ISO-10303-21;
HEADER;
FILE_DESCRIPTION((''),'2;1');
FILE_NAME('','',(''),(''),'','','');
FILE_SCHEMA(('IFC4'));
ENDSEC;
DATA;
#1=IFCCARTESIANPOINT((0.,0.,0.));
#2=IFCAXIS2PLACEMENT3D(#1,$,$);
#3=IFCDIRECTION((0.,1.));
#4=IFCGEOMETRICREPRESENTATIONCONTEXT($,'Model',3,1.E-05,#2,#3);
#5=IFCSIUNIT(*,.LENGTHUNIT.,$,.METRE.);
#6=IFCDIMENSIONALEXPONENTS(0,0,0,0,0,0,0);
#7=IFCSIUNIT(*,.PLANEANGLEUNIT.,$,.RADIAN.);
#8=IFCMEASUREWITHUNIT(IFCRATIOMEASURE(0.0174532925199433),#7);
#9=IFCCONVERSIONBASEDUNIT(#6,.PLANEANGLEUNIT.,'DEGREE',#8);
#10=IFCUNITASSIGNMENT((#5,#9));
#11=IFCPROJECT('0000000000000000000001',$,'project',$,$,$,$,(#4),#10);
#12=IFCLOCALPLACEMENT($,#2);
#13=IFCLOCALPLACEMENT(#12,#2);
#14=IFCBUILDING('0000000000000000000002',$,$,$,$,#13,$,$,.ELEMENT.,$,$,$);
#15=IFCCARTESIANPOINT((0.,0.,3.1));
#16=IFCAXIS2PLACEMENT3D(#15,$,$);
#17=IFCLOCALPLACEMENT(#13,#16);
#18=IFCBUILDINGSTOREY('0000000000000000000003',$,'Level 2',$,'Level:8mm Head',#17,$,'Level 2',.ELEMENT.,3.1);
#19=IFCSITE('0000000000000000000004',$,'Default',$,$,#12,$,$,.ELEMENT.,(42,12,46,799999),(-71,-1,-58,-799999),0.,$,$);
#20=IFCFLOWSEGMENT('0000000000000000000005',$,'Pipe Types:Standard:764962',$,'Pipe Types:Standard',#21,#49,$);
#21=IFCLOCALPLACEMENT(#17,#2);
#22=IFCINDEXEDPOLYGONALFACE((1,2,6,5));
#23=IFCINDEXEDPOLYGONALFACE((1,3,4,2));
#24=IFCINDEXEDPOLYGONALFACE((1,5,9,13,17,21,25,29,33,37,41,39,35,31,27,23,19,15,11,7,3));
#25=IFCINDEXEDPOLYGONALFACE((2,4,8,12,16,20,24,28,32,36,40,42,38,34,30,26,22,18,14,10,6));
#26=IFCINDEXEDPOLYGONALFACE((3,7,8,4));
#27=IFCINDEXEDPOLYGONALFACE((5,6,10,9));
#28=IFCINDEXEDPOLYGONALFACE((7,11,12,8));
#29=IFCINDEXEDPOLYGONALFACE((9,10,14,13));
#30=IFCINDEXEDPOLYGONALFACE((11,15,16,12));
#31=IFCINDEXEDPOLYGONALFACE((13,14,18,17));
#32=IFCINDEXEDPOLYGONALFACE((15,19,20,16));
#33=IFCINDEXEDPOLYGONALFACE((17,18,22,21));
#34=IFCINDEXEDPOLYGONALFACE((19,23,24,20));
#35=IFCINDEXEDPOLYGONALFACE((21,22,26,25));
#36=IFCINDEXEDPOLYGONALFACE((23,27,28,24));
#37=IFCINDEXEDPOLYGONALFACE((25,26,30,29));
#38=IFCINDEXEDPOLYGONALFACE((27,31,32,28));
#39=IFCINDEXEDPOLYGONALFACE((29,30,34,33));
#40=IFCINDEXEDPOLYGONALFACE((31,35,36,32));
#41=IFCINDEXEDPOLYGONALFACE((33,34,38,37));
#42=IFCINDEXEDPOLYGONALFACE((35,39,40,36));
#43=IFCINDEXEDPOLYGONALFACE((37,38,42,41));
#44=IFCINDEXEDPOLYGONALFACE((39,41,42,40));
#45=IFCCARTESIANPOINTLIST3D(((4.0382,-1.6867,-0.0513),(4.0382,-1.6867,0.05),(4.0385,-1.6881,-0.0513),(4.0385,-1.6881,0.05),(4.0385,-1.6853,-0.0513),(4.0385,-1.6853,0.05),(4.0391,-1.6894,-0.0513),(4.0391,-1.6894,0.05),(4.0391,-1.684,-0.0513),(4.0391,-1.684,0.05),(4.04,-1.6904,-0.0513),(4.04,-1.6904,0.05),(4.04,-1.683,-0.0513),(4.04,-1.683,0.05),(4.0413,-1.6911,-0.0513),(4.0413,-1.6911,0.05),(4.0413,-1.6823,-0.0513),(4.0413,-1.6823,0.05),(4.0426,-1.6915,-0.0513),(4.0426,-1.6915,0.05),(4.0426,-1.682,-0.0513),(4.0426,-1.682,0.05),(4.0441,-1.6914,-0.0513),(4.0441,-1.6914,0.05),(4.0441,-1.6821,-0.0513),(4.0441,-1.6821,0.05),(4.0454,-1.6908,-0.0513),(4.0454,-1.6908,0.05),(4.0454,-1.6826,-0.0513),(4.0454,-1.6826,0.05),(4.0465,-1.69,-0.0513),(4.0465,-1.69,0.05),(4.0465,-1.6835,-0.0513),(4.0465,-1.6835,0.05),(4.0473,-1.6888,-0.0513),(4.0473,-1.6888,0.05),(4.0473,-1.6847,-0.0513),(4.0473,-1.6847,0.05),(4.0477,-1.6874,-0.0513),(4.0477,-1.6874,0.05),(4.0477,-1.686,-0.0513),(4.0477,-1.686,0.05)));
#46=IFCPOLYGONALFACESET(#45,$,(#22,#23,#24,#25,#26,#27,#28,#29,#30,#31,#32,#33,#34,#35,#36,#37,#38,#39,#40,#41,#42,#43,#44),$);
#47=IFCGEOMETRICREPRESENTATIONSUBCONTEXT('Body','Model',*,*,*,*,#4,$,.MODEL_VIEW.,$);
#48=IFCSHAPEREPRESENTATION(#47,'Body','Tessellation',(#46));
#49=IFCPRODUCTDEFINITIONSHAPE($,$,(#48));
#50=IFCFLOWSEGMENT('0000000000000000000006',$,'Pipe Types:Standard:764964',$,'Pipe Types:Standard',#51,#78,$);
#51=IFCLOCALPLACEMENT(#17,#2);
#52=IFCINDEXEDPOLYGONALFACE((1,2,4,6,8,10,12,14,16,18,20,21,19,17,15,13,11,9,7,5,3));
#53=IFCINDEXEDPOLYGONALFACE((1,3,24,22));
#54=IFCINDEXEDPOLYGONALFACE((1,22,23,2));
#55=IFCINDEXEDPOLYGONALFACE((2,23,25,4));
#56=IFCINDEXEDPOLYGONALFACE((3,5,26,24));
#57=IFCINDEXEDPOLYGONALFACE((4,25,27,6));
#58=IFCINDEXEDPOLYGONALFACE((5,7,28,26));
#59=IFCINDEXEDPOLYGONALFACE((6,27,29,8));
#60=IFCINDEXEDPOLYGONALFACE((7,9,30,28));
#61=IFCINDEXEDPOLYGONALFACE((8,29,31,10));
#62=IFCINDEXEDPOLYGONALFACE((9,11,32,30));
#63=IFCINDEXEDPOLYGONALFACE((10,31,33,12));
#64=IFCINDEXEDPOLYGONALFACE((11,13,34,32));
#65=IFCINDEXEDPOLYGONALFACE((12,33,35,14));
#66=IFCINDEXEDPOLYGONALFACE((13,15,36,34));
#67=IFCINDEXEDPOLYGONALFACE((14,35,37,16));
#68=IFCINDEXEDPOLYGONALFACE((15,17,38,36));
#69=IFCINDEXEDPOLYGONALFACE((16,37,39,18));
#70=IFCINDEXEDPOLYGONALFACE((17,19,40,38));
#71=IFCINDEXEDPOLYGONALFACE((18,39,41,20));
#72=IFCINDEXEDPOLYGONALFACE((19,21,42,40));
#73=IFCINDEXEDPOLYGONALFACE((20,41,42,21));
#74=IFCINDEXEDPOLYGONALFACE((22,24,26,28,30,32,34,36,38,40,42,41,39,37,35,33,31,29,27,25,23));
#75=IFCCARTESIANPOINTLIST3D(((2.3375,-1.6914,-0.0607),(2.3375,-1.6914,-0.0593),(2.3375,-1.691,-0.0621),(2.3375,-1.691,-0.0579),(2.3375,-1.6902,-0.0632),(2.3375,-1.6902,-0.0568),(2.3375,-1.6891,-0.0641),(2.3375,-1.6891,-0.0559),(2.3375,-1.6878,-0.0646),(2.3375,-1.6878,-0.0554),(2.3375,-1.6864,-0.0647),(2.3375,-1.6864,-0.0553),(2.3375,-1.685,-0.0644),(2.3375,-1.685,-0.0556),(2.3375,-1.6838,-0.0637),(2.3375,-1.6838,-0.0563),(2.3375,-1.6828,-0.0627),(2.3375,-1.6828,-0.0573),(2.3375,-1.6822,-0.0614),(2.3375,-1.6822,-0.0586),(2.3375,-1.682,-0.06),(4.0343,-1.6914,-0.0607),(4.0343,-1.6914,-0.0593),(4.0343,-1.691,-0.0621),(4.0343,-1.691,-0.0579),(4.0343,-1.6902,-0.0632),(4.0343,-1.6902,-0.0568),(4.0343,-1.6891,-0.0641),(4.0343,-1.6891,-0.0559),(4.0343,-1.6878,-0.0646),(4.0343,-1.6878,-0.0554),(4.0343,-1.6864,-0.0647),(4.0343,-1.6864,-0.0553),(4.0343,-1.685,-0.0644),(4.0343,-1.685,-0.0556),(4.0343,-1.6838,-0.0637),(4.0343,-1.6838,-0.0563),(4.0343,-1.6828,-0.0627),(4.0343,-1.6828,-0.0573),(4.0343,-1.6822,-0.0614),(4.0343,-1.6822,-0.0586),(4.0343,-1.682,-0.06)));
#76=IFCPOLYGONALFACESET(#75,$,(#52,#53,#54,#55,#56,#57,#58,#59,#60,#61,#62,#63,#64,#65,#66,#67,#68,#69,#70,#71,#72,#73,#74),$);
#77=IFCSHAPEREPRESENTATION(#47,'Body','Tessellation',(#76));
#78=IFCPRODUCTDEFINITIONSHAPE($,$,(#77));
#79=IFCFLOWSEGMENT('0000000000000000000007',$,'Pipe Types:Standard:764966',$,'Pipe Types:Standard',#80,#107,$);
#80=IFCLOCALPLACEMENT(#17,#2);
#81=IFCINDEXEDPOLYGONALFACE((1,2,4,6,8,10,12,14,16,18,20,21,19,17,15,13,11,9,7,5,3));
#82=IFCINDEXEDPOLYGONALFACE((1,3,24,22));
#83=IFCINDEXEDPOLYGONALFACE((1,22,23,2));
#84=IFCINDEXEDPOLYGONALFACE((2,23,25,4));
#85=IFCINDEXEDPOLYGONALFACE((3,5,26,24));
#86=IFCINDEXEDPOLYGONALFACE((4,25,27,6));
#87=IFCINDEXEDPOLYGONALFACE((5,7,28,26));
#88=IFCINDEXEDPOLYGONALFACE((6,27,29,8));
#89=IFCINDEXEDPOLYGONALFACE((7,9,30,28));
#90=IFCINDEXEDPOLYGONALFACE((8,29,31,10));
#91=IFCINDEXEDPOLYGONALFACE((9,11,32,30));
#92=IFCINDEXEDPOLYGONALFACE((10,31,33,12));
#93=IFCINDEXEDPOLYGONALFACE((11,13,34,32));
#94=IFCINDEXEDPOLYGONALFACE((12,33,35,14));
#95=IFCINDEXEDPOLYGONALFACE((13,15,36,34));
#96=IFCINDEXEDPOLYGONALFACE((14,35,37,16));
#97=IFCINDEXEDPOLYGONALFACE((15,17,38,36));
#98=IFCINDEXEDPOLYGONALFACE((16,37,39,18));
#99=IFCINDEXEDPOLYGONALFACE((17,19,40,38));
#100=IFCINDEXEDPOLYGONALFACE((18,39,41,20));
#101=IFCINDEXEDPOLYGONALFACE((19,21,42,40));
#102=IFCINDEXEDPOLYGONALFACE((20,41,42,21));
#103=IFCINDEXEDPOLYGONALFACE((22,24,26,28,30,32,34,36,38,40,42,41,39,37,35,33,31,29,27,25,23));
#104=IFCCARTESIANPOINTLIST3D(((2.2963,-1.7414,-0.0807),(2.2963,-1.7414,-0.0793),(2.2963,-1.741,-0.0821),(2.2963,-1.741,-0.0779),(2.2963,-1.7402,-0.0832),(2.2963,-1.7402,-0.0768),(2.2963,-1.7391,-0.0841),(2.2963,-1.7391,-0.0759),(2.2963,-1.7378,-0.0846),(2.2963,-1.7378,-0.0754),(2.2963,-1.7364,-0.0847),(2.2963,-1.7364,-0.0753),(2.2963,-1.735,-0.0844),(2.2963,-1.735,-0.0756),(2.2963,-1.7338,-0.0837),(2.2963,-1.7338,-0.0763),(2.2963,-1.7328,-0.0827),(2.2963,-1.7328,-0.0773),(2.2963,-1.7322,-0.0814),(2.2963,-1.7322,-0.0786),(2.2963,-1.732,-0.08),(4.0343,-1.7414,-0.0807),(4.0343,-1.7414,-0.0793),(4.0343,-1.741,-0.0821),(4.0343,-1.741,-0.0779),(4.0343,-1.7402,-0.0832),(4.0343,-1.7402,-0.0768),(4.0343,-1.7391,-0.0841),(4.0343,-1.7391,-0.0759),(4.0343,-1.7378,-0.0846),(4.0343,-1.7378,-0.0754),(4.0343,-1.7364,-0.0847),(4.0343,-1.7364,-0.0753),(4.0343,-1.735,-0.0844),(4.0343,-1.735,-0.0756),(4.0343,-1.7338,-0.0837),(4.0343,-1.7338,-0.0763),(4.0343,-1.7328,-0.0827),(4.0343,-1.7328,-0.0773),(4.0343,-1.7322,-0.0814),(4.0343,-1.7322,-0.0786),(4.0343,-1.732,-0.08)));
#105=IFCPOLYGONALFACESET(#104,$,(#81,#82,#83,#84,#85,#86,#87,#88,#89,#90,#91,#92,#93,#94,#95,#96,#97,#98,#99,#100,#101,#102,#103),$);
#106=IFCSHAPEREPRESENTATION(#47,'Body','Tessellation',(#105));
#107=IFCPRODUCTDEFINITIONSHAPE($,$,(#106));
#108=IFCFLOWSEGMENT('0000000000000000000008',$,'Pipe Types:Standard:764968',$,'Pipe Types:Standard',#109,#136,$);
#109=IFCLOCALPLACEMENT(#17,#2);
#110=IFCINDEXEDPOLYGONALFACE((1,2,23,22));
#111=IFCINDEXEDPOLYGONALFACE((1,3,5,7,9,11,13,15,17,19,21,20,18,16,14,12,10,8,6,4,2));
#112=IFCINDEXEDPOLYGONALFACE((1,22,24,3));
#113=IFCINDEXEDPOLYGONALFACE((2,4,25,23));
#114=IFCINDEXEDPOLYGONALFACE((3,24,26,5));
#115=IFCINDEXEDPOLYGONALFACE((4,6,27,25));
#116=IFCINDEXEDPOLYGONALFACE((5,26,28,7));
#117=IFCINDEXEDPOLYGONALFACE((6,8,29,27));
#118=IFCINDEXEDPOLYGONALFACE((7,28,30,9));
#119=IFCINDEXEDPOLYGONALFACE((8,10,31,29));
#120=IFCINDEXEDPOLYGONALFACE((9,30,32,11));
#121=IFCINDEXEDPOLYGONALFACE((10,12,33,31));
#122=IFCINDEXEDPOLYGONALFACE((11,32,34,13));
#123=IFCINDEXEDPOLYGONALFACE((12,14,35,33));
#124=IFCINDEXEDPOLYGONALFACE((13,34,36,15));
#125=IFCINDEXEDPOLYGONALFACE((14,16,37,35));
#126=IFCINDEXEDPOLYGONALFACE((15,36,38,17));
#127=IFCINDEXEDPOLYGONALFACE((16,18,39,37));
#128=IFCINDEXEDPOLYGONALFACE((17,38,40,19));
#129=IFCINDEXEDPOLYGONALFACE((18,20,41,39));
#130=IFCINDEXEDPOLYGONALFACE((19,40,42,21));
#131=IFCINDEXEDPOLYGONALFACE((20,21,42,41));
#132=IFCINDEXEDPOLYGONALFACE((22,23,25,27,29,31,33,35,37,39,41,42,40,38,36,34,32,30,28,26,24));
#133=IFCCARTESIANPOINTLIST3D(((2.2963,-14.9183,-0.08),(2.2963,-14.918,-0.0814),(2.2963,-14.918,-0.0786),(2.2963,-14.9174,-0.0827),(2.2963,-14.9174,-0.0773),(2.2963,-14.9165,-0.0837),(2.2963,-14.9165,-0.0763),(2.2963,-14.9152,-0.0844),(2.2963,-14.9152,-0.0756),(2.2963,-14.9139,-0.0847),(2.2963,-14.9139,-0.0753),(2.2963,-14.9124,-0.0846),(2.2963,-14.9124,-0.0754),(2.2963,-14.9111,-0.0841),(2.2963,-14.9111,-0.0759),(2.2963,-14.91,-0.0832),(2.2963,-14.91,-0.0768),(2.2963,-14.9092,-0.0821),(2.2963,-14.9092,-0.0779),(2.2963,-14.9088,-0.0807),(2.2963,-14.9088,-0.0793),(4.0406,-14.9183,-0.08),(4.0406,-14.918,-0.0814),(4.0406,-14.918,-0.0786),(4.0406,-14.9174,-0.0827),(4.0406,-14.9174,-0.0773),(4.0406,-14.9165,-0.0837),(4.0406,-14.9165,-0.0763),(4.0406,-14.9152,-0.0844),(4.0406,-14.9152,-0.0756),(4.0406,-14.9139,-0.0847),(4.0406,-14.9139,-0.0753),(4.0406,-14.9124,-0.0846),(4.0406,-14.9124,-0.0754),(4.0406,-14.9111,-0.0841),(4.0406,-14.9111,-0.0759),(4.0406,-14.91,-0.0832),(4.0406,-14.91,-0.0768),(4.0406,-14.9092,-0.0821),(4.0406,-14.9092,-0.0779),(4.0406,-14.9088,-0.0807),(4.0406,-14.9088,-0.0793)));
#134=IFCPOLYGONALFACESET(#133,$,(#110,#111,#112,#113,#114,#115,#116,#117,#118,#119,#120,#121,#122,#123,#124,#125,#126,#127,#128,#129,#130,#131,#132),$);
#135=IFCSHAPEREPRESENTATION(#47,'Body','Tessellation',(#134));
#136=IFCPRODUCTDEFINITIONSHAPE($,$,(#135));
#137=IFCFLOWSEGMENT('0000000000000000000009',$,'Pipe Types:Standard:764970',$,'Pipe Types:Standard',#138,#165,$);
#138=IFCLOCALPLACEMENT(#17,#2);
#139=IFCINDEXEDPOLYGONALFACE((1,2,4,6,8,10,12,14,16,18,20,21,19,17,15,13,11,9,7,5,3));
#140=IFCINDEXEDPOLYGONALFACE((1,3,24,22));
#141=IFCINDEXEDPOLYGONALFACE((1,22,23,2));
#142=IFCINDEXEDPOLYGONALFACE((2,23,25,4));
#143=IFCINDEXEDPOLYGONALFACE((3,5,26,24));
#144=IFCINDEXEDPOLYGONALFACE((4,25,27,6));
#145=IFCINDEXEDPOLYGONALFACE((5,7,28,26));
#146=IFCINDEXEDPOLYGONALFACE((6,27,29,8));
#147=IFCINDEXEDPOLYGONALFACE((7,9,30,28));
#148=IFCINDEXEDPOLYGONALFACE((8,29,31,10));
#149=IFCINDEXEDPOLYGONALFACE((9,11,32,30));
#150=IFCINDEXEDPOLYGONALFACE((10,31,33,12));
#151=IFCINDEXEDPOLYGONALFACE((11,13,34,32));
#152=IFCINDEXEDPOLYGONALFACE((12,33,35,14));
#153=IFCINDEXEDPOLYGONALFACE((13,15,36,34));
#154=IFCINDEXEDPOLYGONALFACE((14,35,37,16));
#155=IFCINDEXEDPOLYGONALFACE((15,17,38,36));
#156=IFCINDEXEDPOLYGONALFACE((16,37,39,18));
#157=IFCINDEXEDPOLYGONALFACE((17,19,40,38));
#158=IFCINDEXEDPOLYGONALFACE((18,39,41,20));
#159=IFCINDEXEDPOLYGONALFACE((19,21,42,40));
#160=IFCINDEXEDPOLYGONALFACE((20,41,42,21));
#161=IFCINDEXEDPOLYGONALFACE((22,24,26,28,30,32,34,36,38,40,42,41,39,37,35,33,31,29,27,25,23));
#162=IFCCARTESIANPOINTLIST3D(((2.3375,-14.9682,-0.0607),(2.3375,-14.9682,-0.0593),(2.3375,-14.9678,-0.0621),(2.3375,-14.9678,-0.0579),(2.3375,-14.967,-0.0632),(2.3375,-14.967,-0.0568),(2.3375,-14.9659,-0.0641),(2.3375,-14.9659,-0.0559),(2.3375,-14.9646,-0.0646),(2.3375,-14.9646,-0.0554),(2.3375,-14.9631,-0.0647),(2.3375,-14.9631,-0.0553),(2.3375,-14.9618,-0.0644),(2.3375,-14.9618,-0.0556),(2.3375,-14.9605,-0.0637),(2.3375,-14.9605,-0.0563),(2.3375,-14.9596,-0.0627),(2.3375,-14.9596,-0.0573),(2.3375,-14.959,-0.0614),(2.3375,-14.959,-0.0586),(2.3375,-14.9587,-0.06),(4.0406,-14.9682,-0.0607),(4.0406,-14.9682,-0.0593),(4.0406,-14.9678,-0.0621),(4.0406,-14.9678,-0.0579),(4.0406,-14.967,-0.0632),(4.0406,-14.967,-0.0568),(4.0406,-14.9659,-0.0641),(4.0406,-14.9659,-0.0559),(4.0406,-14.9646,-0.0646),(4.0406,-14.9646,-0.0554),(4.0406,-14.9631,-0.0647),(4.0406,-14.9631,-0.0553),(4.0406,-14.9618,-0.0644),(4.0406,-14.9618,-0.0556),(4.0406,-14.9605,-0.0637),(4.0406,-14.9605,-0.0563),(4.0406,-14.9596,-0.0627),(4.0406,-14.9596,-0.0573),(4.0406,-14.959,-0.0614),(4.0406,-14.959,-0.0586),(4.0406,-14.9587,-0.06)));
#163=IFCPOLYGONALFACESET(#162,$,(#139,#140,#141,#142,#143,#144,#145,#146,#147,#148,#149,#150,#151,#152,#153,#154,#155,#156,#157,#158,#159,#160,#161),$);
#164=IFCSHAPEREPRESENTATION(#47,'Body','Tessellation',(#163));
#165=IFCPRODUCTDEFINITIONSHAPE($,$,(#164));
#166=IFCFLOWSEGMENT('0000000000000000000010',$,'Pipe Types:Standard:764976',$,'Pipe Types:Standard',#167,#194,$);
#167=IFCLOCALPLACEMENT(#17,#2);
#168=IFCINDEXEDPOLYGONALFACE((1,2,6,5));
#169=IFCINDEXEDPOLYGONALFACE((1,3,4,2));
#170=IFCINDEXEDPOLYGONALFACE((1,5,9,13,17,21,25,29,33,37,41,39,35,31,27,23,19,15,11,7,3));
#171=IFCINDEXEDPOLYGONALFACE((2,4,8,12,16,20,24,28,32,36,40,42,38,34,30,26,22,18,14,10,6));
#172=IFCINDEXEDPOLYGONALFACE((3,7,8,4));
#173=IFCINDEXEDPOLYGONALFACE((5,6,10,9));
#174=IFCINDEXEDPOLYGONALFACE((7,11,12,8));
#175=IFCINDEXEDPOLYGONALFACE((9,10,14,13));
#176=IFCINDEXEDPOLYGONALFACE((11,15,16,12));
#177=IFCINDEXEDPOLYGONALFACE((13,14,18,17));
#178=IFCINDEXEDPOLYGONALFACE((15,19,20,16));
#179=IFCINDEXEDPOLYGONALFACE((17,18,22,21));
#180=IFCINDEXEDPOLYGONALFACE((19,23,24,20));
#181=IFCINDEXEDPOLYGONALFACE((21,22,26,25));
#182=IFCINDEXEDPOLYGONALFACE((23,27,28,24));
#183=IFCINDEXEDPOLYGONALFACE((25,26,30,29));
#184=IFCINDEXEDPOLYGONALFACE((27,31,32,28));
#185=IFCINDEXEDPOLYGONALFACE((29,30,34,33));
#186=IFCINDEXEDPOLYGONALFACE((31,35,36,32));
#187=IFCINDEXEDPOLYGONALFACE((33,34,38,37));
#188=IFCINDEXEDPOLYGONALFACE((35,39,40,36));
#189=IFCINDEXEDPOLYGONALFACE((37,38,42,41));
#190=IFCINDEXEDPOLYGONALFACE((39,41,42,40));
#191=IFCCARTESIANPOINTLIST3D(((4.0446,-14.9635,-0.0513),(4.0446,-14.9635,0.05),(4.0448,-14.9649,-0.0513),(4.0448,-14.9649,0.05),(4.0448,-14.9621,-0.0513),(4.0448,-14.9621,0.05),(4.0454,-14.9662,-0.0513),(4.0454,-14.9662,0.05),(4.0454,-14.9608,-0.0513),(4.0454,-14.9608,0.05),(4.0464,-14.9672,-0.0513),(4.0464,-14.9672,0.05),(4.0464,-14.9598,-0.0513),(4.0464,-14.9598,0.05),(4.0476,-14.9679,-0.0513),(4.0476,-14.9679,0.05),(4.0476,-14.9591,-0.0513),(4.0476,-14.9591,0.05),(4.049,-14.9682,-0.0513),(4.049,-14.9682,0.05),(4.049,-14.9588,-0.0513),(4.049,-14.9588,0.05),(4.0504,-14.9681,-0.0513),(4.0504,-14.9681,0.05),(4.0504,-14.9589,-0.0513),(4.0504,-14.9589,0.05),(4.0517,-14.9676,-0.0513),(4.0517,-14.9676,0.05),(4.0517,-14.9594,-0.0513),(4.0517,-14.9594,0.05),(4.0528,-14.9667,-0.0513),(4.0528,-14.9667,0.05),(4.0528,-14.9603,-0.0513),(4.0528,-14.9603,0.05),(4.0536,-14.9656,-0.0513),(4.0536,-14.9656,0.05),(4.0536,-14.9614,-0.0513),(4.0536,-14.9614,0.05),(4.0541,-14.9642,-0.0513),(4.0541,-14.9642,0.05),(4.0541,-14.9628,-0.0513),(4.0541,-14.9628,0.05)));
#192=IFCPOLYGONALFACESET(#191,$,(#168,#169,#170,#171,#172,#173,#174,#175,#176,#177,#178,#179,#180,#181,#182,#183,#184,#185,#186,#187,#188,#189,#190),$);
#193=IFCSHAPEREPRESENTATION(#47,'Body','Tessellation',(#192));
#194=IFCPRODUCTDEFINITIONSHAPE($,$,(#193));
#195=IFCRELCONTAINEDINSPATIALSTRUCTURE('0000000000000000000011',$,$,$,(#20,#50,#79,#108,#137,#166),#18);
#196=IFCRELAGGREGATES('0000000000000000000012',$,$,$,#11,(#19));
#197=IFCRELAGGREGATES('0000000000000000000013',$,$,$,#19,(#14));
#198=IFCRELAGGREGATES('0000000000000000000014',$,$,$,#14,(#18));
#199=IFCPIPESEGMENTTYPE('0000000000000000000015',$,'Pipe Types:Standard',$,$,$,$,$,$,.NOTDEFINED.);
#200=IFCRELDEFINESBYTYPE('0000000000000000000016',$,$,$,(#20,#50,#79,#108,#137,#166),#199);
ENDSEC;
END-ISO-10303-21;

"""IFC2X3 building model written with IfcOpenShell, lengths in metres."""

from ifc_helpers import new_model, entity, si_unit, converted_unit, direction, frame, frame_2d, origin, origin_2d_with_axis, place, context, subcontext, project, spatial, circle, extrude, type_object, element, save


model = new_model("IFC2X3")

# Units and contexts
model_context = context("Model", 3, precision=1e-05, world=origin(), true_north=direction((0.0, 1.0)))
body_context = subcontext(model_context, "Body", "Model", "MODEL_VIEW")
ifc_project = project(units=[si_unit("LENGTHUNIT", "METRE"), converted_unit("PLANEANGLEUNIT", "DEGREE", entity("IfcRatioMeasure", 0.0174532925199433), si_unit("PLANEANGLEUNIT", "RADIAN"), dimensions=[0, 0, 0, 0, 0, 0, 0])], contexts=[model_context])

# Site, building, storey
site_placement = place(None, origin())
site = spatial("IfcSite", under=ifc_project, at=site_placement, Name="Default", CompositionType="ELEMENT", RefLatitude=(42, 12, 46, 799999), RefLongitude=(-71, -1, -58, -799999), RefElevation=0.0)
building_placement = place(site_placement, origin())
building = spatial("IfcBuilding", under=site, at=building_placement, CompositionType="ELEMENT")
storey_placement = place(building_placement, frame((0.0, 0.0, 3.1)))
storey = spatial("IfcBuildingStorey", under=building, at=storey_placement, Name="Level 2", ObjectType="Level:8mm Head", LongName="Level 2", CompositionType="ELEMENT", Elevation=3.1)

# Flow segments
pipe_segment_type = type_object("IfcPipeSegmentType", Name="Pipe Types:Standard", PredefinedType="NOTDEFINED")
flow_segment_1_placement = place(storey_placement, origin())
element("IfcFlowSegment", 1, at=flow_segment_1_placement, inside=storey, type_object=pipe_segment_type, Name="Pipe Types:Standard:764962", ObjectType="Pipe Types:Standard", context=body_context, shape_type="SweptSolid", body=[
    extrude(circle(Radius=0.0048, at=origin_2d_with_axis()), frame((4.043, -1.6867, -0.0513), z_axis=(0.0, 0.0, 1.0), x_axis=(-1.0, 0.0, 0.0)), (0.0, 0.0, 1.0), 0.1013),
])
flow_segment_2_placement = place(storey_placement, origin())
element("IfcFlowSegment", 2, at=flow_segment_2_placement, inside=storey, type_object=pipe_segment_type, Name="Pipe Types:Standard:764964", ObjectType="Pipe Types:Standard", context=body_context, shape_type="SweptSolid", body=[
    extrude(circle(Radius=0.0048, at=frame_2d((0.0, 0.0), x_axis=(1.0, 0.0))), frame((2.3375, -1.6867, -0.06), z_axis=(1.0, 0.0, 0.0), x_axis=(0.0, 1.0, 0.0)), (0.0, 0.0, 1.0), 1.6968),
])
flow_segment_3_placement = place(storey_placement, origin())
element("IfcFlowSegment", 3, at=flow_segment_3_placement, inside=storey, type_object=pipe_segment_type, Name="Pipe Types:Standard:764966", ObjectType="Pipe Types:Standard", context=body_context, shape_type="SweptSolid", body=[
    extrude(circle(Radius=0.0048, at=frame_2d((0.0, 0.0), x_axis=(1.0, 0.0))), frame((2.2963, -1.7367, -0.08), z_axis=(1.0, 0.0, 0.0), x_axis=(0.0, 1.0, 0.0)), (0.0, 0.0, 1.0), 1.738),
])
flow_segment_4_placement = place(storey_placement, origin())
element("IfcFlowSegment", 4, at=flow_segment_4_placement, inside=storey, type_object=pipe_segment_type, Name="Pipe Types:Standard:764968", ObjectType="Pipe Types:Standard", context=body_context, shape_type="SweptSolid", body=[
    extrude(circle(Radius=0.0048, at=origin_2d_with_axis()), frame((2.2963, -14.9135, -0.08), z_axis=(1.0, 0.0, 0.0), x_axis=(0.0, -1.0, 0.0)), (0.0, 0.0, 1.0), 1.7444),
])
flow_segment_5_placement = place(storey_placement, origin())
element("IfcFlowSegment", 5, at=flow_segment_5_placement, inside=storey, type_object=pipe_segment_type, Name="Pipe Types:Standard:764970", ObjectType="Pipe Types:Standard", context=body_context, shape_type="SweptSolid", body=[
    extrude(circle(Radius=0.0048, at=frame_2d((0.0, 0.0), x_axis=(1.0, 0.0))), frame((2.3375, -14.9635, -0.06), z_axis=(1.0, 0.0, 0.0), x_axis=(0.0, 1.0, 0.0)), (0.0, 0.0, 1.0), 1.7031),
])
flow_segment_6_placement = place(storey_placement, origin())
element("IfcFlowSegment", 6, at=flow_segment_6_placement, inside=storey, type_object=pipe_segment_type, Name="Pipe Types:Standard:764976", ObjectType="Pipe Types:Standard", context=body_context, shape_type="SweptSolid", body=[
    extrude(circle(Radius=0.0048, at=origin_2d_with_axis()), frame((4.0494, -14.9635, -0.0513), z_axis=(0.0, 0.0, 1.0), x_axis=(-1.0, 0.0, 0.0)), (0.0, 0.0, 1.0), 0.1013),
])

save(model, "model.ifc")
